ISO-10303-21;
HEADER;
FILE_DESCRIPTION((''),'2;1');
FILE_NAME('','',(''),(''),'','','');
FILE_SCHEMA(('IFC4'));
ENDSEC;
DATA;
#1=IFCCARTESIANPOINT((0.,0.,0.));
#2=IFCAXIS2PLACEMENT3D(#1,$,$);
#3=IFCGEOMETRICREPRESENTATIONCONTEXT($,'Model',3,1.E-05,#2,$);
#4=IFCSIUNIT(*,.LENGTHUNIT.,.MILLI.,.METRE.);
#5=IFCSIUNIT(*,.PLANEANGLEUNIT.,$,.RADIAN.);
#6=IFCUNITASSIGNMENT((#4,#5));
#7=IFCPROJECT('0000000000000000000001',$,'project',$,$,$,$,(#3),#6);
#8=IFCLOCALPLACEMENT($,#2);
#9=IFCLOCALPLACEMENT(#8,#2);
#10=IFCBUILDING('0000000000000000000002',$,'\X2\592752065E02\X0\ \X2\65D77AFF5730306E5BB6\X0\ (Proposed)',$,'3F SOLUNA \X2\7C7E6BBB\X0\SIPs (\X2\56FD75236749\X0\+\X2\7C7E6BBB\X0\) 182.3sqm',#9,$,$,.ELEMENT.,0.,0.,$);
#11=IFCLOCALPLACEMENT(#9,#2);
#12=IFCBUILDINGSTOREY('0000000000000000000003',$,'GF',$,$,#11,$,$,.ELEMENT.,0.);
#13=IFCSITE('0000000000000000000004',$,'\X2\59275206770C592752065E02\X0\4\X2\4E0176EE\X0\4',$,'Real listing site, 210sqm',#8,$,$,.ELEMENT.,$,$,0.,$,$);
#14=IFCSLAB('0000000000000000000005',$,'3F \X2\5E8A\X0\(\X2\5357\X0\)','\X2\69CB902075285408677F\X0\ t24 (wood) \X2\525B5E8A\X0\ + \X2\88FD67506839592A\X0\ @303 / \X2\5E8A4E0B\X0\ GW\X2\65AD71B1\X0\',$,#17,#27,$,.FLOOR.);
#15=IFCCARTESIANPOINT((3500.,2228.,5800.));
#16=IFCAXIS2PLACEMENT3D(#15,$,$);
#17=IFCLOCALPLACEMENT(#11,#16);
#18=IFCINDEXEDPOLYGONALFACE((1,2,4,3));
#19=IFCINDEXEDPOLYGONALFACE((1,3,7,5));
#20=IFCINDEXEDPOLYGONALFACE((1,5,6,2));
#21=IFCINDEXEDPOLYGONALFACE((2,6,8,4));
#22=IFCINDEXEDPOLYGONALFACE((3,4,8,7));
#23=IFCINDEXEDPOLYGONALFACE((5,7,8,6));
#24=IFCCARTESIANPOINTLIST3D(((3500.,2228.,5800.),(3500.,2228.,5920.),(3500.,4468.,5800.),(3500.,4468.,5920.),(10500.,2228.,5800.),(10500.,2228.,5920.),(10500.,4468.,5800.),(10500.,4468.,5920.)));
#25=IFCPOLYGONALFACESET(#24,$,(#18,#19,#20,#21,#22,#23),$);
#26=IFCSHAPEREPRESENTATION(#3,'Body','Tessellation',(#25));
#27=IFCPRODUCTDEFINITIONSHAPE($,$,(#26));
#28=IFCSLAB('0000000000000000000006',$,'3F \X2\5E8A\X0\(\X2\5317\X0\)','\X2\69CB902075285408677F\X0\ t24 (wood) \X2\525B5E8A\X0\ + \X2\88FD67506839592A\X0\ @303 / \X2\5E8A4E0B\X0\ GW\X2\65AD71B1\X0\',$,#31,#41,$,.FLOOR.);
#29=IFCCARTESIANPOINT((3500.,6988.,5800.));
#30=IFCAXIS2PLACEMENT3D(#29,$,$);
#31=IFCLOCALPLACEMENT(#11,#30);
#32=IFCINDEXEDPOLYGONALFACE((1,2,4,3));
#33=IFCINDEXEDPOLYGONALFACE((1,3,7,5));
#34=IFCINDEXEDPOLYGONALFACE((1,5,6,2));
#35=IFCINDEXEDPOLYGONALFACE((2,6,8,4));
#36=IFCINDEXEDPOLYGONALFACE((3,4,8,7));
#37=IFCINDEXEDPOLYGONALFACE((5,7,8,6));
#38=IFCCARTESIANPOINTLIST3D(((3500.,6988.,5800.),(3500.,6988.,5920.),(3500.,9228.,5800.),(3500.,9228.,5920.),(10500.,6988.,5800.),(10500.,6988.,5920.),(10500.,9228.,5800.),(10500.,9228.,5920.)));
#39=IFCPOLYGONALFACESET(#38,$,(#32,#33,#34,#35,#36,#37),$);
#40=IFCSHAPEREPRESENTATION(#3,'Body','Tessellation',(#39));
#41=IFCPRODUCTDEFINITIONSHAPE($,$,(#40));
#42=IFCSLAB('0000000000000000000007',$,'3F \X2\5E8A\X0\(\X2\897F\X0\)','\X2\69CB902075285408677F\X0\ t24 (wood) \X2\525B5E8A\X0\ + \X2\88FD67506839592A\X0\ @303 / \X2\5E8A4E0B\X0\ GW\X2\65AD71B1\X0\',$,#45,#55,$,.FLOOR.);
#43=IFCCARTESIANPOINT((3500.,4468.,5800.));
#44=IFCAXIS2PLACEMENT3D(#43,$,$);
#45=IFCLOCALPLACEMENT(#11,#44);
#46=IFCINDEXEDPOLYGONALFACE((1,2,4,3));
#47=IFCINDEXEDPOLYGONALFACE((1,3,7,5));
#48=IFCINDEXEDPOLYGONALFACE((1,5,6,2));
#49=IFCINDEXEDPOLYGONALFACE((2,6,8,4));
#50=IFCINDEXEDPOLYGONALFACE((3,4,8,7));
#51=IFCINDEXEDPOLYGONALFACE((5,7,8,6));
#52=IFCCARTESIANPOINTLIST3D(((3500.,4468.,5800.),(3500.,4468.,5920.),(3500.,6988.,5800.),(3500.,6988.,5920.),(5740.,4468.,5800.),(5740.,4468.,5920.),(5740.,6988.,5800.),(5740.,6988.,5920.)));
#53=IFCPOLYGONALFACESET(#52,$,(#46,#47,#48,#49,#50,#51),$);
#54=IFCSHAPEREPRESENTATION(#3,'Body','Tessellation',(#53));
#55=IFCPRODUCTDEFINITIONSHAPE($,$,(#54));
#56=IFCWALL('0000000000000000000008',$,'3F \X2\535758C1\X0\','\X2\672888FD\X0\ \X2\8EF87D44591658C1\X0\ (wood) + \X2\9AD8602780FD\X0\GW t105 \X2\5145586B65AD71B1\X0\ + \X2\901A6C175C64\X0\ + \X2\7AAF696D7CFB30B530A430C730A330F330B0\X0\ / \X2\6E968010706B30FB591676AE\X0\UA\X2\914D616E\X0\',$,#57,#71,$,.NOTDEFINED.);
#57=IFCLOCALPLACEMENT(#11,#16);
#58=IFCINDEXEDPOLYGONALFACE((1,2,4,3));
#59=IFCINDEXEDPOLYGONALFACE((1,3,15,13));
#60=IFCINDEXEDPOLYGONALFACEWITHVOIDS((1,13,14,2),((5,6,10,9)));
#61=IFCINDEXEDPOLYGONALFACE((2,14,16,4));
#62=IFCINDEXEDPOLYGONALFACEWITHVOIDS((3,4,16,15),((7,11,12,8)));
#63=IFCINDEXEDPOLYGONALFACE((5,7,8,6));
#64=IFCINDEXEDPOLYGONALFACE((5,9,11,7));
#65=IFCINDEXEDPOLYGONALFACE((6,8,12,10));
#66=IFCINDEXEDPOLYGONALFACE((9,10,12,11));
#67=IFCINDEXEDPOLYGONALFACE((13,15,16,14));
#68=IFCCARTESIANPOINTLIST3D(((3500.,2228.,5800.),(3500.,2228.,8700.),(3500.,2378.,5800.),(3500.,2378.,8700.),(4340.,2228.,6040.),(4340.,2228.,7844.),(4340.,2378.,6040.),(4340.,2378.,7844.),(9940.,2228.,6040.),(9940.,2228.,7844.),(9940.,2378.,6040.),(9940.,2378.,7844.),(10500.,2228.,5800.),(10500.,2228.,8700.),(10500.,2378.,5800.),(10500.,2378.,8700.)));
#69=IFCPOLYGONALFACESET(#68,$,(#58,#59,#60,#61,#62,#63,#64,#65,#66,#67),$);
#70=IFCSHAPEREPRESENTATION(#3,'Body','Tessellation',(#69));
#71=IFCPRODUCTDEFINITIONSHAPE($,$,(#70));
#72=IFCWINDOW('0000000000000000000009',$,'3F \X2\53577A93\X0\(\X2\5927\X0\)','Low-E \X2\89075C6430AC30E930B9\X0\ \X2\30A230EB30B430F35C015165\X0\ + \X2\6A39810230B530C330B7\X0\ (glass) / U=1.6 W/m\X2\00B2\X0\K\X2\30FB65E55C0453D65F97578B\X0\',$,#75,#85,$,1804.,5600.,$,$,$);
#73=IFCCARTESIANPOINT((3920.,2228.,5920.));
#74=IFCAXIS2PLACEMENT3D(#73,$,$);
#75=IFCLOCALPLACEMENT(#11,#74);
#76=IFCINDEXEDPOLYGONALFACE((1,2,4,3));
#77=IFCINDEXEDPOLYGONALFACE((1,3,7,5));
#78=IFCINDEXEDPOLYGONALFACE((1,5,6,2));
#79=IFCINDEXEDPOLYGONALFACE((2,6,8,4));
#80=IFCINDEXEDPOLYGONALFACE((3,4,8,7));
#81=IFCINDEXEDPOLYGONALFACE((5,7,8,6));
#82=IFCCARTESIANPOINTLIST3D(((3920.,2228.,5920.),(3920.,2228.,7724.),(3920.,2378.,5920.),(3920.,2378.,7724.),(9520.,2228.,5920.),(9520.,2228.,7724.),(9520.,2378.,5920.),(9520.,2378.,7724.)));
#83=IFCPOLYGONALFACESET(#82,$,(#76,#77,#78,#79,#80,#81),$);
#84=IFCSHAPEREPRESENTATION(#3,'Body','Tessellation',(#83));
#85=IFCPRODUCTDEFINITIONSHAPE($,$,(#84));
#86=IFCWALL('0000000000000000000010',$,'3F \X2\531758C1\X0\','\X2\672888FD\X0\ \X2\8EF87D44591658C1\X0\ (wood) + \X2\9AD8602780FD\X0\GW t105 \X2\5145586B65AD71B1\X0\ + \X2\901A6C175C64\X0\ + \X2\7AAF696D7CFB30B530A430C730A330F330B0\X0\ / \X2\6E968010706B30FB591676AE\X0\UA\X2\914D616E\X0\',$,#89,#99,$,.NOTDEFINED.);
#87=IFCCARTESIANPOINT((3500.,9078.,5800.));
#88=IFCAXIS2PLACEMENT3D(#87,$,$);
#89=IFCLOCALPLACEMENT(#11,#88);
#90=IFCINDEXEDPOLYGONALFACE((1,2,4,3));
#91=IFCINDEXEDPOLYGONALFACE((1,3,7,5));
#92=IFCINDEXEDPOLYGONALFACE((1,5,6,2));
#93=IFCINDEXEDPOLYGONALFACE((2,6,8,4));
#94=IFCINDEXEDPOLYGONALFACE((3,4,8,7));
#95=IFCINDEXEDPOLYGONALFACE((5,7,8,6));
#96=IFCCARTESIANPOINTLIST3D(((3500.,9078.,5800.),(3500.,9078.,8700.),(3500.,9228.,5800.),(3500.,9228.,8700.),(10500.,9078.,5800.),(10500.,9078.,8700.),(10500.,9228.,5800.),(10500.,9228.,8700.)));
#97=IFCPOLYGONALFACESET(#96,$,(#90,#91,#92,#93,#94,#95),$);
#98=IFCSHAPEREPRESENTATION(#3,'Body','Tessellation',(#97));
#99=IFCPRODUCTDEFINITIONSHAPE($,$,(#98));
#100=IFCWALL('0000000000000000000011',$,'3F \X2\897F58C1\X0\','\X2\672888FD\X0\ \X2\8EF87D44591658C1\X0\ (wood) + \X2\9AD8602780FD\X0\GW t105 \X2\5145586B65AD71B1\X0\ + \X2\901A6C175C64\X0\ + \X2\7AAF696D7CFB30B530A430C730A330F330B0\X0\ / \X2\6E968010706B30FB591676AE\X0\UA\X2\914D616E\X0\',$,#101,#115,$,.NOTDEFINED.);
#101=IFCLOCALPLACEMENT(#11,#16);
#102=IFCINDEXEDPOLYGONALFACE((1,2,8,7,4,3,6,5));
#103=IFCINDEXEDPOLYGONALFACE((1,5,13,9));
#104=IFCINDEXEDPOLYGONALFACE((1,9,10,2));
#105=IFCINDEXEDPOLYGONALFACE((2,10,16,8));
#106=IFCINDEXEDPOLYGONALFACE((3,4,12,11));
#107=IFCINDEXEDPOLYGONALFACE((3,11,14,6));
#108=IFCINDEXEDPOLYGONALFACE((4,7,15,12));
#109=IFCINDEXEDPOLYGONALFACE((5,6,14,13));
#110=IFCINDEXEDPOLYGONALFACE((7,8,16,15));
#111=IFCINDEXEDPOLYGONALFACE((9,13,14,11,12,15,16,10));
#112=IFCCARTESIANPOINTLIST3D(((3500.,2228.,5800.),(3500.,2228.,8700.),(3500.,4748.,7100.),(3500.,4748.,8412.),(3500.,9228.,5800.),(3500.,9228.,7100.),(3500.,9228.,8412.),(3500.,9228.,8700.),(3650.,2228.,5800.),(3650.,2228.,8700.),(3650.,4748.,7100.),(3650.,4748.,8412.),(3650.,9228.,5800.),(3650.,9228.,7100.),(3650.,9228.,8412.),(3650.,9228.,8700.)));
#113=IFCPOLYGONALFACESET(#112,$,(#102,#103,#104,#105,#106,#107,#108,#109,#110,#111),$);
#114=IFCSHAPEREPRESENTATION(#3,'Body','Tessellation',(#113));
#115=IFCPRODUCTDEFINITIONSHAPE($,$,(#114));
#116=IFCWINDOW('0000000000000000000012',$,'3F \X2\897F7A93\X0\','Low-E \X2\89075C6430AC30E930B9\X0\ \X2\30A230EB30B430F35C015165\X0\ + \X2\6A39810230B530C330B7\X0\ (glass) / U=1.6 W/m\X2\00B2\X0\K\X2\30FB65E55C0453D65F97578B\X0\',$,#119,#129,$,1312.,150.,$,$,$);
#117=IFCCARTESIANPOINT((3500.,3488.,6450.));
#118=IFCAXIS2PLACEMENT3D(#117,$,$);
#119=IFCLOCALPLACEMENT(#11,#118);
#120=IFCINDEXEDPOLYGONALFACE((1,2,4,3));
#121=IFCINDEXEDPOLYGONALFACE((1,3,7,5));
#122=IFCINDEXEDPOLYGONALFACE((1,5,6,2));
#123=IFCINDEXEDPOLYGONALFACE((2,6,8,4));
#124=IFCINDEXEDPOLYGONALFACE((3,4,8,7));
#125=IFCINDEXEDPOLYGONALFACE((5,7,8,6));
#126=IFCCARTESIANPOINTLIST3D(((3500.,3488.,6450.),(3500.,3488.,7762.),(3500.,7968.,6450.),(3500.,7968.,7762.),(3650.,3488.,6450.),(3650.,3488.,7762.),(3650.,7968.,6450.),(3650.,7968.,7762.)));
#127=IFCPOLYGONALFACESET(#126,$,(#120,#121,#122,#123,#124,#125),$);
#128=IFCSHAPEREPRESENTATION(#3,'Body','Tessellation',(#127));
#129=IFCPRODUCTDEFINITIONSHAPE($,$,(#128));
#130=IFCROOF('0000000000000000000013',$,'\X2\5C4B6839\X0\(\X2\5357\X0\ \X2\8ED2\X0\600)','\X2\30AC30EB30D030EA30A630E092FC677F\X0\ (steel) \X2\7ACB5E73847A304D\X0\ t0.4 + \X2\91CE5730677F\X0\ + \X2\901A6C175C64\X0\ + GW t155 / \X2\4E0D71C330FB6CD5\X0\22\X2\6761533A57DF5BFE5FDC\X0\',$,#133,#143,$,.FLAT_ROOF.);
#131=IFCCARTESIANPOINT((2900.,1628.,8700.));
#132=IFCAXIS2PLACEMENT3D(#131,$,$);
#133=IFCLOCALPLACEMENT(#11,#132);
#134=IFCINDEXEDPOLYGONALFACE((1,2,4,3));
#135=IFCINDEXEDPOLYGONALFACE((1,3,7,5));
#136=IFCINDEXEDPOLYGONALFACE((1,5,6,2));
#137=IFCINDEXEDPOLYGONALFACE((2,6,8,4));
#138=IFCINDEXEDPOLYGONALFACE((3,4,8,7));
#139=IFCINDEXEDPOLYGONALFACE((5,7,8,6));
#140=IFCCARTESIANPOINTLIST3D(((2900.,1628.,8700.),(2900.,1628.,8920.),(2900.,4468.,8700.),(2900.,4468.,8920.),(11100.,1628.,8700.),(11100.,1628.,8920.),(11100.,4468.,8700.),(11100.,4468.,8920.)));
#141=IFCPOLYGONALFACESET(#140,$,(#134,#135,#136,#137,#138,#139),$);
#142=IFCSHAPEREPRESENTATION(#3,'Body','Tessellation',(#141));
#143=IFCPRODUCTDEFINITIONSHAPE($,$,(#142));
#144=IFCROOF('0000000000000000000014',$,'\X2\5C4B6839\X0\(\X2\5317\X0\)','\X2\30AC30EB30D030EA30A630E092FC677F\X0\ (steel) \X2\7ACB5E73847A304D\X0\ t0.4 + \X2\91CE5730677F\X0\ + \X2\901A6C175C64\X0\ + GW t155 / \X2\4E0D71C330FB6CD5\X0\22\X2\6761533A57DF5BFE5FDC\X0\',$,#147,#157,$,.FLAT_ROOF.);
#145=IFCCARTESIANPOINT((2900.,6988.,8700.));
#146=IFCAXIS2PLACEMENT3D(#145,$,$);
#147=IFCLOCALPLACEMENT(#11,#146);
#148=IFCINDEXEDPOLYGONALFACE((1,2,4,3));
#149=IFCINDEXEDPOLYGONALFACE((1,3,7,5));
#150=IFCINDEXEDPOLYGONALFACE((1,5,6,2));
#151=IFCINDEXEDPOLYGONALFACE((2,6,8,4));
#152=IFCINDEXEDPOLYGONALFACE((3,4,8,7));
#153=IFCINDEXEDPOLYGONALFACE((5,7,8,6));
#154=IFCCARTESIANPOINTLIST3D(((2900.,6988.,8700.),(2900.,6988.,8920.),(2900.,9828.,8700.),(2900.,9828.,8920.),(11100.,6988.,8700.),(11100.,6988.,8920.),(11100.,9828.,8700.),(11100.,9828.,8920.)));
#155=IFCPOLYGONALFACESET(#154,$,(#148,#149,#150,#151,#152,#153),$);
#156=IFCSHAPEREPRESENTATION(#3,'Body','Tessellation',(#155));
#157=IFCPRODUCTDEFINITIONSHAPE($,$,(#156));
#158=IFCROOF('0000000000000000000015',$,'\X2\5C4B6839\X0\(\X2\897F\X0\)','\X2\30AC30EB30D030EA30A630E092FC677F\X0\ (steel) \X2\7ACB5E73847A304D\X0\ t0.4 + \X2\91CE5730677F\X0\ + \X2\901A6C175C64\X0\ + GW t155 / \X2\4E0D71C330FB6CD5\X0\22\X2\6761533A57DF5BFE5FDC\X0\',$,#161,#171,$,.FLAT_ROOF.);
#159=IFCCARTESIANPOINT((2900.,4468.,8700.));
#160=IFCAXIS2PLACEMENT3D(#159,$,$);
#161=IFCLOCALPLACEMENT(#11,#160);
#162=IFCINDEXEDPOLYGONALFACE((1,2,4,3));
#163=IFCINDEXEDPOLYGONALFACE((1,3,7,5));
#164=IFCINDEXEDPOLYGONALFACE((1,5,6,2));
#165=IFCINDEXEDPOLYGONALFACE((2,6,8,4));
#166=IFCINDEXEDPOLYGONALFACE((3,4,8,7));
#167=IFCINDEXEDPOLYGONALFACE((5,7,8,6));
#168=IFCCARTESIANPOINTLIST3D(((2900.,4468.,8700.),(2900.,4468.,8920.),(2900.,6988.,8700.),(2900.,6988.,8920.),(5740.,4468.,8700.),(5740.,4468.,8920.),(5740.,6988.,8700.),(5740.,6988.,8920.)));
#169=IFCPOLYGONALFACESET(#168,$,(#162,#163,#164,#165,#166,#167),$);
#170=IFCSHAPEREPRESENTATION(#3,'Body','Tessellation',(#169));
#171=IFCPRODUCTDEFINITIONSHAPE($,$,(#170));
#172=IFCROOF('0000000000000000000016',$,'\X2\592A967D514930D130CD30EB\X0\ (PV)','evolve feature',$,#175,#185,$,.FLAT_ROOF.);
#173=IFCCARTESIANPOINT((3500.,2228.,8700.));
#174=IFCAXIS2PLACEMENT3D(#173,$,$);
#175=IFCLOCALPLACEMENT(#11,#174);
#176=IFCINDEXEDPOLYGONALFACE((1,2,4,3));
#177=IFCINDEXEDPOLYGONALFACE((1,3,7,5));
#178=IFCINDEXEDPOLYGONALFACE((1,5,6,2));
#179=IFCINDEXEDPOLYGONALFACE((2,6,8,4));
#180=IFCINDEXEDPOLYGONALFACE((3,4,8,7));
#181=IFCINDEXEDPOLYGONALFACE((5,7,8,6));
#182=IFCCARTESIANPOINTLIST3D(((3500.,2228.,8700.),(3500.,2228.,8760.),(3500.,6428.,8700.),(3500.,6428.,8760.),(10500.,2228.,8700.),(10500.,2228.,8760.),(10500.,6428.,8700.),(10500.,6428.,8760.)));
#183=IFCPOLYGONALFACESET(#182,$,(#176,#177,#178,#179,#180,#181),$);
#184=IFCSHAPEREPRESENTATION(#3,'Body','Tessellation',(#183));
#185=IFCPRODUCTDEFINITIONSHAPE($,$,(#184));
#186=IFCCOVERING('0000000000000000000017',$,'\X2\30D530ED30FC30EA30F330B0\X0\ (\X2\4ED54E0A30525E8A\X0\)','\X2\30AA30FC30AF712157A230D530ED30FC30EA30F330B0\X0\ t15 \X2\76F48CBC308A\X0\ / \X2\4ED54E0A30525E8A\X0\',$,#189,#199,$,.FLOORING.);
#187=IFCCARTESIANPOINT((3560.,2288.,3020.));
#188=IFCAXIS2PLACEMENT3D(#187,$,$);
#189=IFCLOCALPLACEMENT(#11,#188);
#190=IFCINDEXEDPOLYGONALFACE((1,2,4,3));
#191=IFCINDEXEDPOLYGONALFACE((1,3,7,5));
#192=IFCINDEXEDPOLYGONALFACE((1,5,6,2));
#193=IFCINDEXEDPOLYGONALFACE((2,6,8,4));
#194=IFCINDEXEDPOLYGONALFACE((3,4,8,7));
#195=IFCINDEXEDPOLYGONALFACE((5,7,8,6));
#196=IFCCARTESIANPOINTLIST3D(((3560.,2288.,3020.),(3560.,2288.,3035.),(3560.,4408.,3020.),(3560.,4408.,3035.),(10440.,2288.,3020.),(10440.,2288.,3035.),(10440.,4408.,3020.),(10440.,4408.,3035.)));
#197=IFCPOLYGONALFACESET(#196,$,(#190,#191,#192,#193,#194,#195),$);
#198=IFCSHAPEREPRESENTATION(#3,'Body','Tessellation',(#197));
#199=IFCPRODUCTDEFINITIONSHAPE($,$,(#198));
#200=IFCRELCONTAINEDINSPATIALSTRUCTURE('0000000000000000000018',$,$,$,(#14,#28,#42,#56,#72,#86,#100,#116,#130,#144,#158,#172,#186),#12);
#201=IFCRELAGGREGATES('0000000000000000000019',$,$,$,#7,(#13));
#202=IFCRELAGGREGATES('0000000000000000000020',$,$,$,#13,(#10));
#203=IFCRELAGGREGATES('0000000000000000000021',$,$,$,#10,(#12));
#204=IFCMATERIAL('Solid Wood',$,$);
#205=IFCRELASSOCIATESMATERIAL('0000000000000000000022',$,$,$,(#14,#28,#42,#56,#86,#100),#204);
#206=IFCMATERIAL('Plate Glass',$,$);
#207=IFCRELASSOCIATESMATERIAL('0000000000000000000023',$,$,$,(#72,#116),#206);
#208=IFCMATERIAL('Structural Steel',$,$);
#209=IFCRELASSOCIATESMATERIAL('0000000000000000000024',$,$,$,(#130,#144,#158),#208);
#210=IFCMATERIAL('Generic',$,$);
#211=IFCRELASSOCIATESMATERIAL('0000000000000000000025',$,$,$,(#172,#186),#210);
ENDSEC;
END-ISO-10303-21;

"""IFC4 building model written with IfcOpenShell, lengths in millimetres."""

from ifc_helpers import new_model, si_unit, frame, frame_2d, origin, place, context, project, spatial, rectangle, extrude, material, element, fill, save


model = new_model("IFC4")

# Units and contexts
model_context = context("Model", 3, precision=1e-05, world=origin())
ifc_project = project(units=[si_unit("LENGTHUNIT", "METRE", prefix="MILLI"), si_unit("PLANEANGLEUNIT", "RADIAN")], contexts=[model_context])

# Site, building, storey
site_placement = place(None, origin())
site = spatial("IfcSite", under=ifc_project, at=site_placement, Name="大分県大分市4丁目4", ObjectType="Real listing site, 210sqm", CompositionType="ELEMENT", RefElevation=0.0)
building_placement = place(site_placement, origin())
building = spatial("IfcBuilding", under=site, at=building_placement, Name="大分市 旗竿地の家 (Proposed)", ObjectType="3F SOLUNA 籾殻SIPs (国産杉+籾殻) 182.3sqm", CompositionType="ELEMENT", ElevationOfRefHeight=0.0, ElevationOfTerrain=0.0)
storey_placement = place(building_placement, origin())
storey = spatial("IfcBuildingStorey", under=building, at=storey_placement, Name="GF", CompositionType="ELEMENT", Elevation=0.0)

# Slabs
ifc_material_1 = material(Name="Solid Wood")
slab_1_placement = place(storey_placement, frame((3500.0, 2228.0, 5800.0)))
element("IfcSlab", 1, at=slab_1_placement, inside=storey, material=ifc_material_1, Name="3F 床(南)", Description="構造用合板 t24 (wood) 剛床 + 製材根太 @303 / 床下 GW断熱", PredefinedType="FLOOR", context=model_context, shape_type="SweptSolid", body=[
    extrude(rectangle(XDim=7000.0, YDim=2240.0, at=frame_2d((3500.0, 1120.0))), frame((3500.0, 2228.0, 5800.0)), (0.0, 0.0, 1.0), 120.0),
])
slab_2_placement = place(storey_placement, frame((3500.0, 6988.0, 5800.0)))
element("IfcSlab", 2, at=slab_2_placement, inside=storey, material=ifc_material_1, Name="3F 床(北)", Description="構造用合板 t24 (wood) 剛床 + 製材根太 @303 / 床下 GW断熱", PredefinedType="FLOOR", context=model_context, shape_type="SweptSolid", body=[
    extrude(rectangle(XDim=7000.0, YDim=2240.0, at=frame_2d((3500.0, 1120.0))), frame((3500.0, 6988.0, 5800.0)), (0.0, 0.0, 1.0), 120.0),
])
slab_3_placement = place(storey_placement, frame((3500.0, 4468.0, 5800.0)))
element("IfcSlab", 3, at=slab_3_placement, inside=storey, material=ifc_material_1, Name="3F 床(西)", Description="構造用合板 t24 (wood) 剛床 + 製材根太 @303 / 床下 GW断熱", PredefinedType="FLOOR", context=model_context, shape_type="SweptSolid", body=[
    extrude(rectangle(XDim=2240.0, YDim=2520.0, at=frame_2d((1120.0, 1260.0))), frame((3500.0, 4468.0, 5800.0)), (0.0, 0.0, 1.0), 120.0),
])

# Wall, opening, window
wall_1_placement = place(storey_placement, frame((3500.0, 2228.0, 5800.0)))
wall_1 = element("IfcWall", 4, at=wall_1_placement, inside=storey, material=ifc_material_1, Name="3F 南壁", Description="木製 軸組外壁 (wood) + 高性能GW t105 充填断熱 + 通気層 + 窯業系サイディング / 準耐火・外皮UA配慮", PredefinedType="NOTDEFINED", context=model_context, shape_type="SweptSolid", body=[
    extrude(rectangle(XDim=7000.0, YDim=150.0, at=frame_2d((3500.0, 75.0))), frame((3500.0, 2228.0, 5800.0)), (0.0, 0.0, 1.0), 2900.0),
])
opening_1_placement = place(storey_placement, frame((3920.0, 2228.0, 5920.0)))
opening_1 = element("IfcOpeningElement", 5, at=opening_1_placement, cuts=wall_1, PredefinedType="NOTDEFINED", context=model_context, shape_type="SweptSolid", body=[
    extrude(rectangle(XDim=5600.0, YDim=150.0, at=frame_2d((2800.0, 75.0))), frame((3920.0, 2228.0, 5920.0)), (0.0, 0.0, 1.0), 1804.0),
])
ifc_material_2 = material(Name="Plate Glass")
window_1_placement = place(storey_placement, frame((3920.0, 2228.0, 5920.0)))
window_1 = element("IfcWindow", 6, at=window_1_placement, inside=storey, material=ifc_material_2, Name="3F 南窓(大)", Description="Low-E 複層ガラス アルゴン封入 + 樹脂サッシ (glass) / U=1.6 W/m²K・日射取得型", OverallHeight=1804.0, OverallWidth=5600.0, context=model_context, shape_type="SweptSolid", body=[
    extrude(rectangle(XDim=5600.0, YDim=150.0, at=frame_2d((2800.0, 75.0))), frame((3920.0, 2228.0, 5920.0)), (0.0, 0.0, 1.0), 1804.0),
])
fill(opening_1, window_1)

# Wall
wall_2_placement = place(storey_placement, frame((3500.0, 9078.0, 5800.0)))
element("IfcWall", 7, at=wall_2_placement, inside=storey, material=ifc_material_1, Name="3F 北壁", Description="木製 軸組外壁 (wood) + 高性能GW t105 充填断熱 + 通気層 + 窯業系サイディング / 準耐火・外皮UA配慮", PredefinedType="NOTDEFINED", context=model_context, shape_type="SweptSolid", body=[
    extrude(rectangle(XDim=7000.0, YDim=150.0, at=frame_2d((3500.0, 75.0))), frame((3500.0, 9078.0, 5800.0)), (0.0, 0.0, 1.0), 2900.0),
])

# Wall, opening, window
wall_3_placement = place(storey_placement, frame((3500.0, 2228.0, 5800.0)))
wall_3 = element("IfcWall", 8, at=wall_3_placement, inside=storey, material=ifc_material_1, Name="3F 西壁", Description="木製 軸組外壁 (wood) + 高性能GW t105 充填断熱 + 通気層 + 窯業系サイディング / 準耐火・外皮UA配慮", PredefinedType="NOTDEFINED", context=model_context, shape_type="SweptSolid", body=[
    extrude(rectangle(XDim=150.0, YDim=7000.0, at=frame_2d((75.0, 3500.0))), frame((3500.0, 2228.0, 5800.0)), (0.0, 0.0, 1.0), 2900.0),
])
opening_2_placement = place(storey_placement, frame((3500.0, 3488.0, 6450.0)))
opening_2 = element("IfcOpeningElement", 9, at=opening_2_placement, cuts=wall_3, PredefinedType="NOTDEFINED", context=model_context, shape_type="SweptSolid", body=[
    extrude(rectangle(XDim=150.0, YDim=4480.0, at=frame_2d((75.0, 2240.0))), frame((3500.0, 3488.0, 6450.0)), (0.0, 0.0, 1.0), 1312.0),
])
window_2_placement = place(storey_placement, frame((3500.0, 3488.0, 6450.0)))
window_2 = element("IfcWindow", 10, at=window_2_placement, inside=storey, material=ifc_material_2, Name="3F 西窓", Description="Low-E 複層ガラス アルゴン封入 + 樹脂サッシ (glass) / U=1.6 W/m²K・日射取得型", OverallHeight=1312.0, OverallWidth=150.0, context=model_context, shape_type="SweptSolid", body=[
    extrude(rectangle(XDim=150.0, YDim=4480.0, at=frame_2d((75.0, 2240.0))), frame((3500.0, 3488.0, 6450.0)), (0.0, 0.0, 1.0), 1312.0),
])
fill(opening_2, window_2)

# Roofs
ifc_material_3 = material(Name="Structural Steel")
roof_1_placement = place(storey_placement, frame((2900.0, 1628.0, 8700.0)))
element("IfcRoof", 11, at=roof_1_placement, inside=storey, material=ifc_material_3, Name="屋根(南 軒600)", Description="ガルバリウム鋼板 (steel) 立平葺き t0.4 + 野地板 + 通気層 + GW t155 / 不燃・法22条区域対応", PredefinedType="FLAT_ROOF", context=model_context, shape_type="SweptSolid", body=[
    extrude(rectangle(XDim=8200.0, YDim=2840.0, at=frame_2d((4100.0, 1420.0))), frame((2900.0, 1628.0, 8700.0)), (0.0, 0.0, 1.0), 220.0),
])
roof_2_placement = place(storey_placement, frame((2900.0, 6988.0, 8700.0)))
element("IfcRoof", 12, at=roof_2_placement, inside=storey, material=ifc_material_3, Name="屋根(北)", Description="ガルバリウム鋼板 (steel) 立平葺き t0.4 + 野地板 + 通気層 + GW t155 / 不燃・法22条区域対応", PredefinedType="FLAT_ROOF", context=model_context, shape_type="SweptSolid", body=[
    extrude(rectangle(XDim=8200.0, YDim=2840.0, at=frame_2d((4100.0, 1420.0))), frame((2900.0, 6988.0, 8700.0)), (0.0, 0.0, 1.0), 220.0),
])
roof_3_placement = place(storey_placement, frame((2900.0, 4468.0, 8700.0)))
element("IfcRoof", 13, at=roof_3_placement, inside=storey, material=ifc_material_3, Name="屋根(西)", Description="ガルバリウム鋼板 (steel) 立平葺き t0.4 + 野地板 + 通気層 + GW t155 / 不燃・法22条区域対応", PredefinedType="FLAT_ROOF", context=model_context, shape_type="SweptSolid", body=[
    extrude(rectangle(XDim=2840.0, YDim=2520.0, at=frame_2d((1420.0, 1260.0))), frame((2900.0, 4468.0, 8700.0)), (0.0, 0.0, 1.0), 220.0),
])
ifc_material_4 = material(Name="Generic")
roof_4_placement = place(storey_placement, frame((3500.0, 2228.0, 8700.0)))
element("IfcRoof", 14, at=roof_4_placement, inside=storey, material=ifc_material_4, Name="太陽光パネル (PV)", Description="evolve feature", PredefinedType="FLAT_ROOF", context=model_context, shape_type="SweptSolid", body=[
    extrude(rectangle(XDim=7000.0, YDim=4200.0, at=frame_2d((3500.0, 2100.0))), frame((3500.0, 2228.0, 8700.0)), (0.0, 0.0, 1.0), 60.0),
])

# Covering
covering_1_placement = place(storey_placement, frame((3560.0, 2288.0, 3020.0)))
element("IfcCovering", 15, at=covering_1_placement, inside=storey, material=ifc_material_4, Name="フローリング (仕上げ床)", Description="オーク無垢フローリング t15 直貼り / 仕上げ床", PredefinedType="FLOORING", context=model_context, shape_type="SweptSolid", body=[
    extrude(rectangle(XDim=6880.0, YDim=2120.0, at=frame_2d((3440.0, 1060.0))), frame((3560.0, 2288.0, 3020.0)), (0.0, 0.0, 1.0), 15.0),
])

save(model, "model.ifc")
